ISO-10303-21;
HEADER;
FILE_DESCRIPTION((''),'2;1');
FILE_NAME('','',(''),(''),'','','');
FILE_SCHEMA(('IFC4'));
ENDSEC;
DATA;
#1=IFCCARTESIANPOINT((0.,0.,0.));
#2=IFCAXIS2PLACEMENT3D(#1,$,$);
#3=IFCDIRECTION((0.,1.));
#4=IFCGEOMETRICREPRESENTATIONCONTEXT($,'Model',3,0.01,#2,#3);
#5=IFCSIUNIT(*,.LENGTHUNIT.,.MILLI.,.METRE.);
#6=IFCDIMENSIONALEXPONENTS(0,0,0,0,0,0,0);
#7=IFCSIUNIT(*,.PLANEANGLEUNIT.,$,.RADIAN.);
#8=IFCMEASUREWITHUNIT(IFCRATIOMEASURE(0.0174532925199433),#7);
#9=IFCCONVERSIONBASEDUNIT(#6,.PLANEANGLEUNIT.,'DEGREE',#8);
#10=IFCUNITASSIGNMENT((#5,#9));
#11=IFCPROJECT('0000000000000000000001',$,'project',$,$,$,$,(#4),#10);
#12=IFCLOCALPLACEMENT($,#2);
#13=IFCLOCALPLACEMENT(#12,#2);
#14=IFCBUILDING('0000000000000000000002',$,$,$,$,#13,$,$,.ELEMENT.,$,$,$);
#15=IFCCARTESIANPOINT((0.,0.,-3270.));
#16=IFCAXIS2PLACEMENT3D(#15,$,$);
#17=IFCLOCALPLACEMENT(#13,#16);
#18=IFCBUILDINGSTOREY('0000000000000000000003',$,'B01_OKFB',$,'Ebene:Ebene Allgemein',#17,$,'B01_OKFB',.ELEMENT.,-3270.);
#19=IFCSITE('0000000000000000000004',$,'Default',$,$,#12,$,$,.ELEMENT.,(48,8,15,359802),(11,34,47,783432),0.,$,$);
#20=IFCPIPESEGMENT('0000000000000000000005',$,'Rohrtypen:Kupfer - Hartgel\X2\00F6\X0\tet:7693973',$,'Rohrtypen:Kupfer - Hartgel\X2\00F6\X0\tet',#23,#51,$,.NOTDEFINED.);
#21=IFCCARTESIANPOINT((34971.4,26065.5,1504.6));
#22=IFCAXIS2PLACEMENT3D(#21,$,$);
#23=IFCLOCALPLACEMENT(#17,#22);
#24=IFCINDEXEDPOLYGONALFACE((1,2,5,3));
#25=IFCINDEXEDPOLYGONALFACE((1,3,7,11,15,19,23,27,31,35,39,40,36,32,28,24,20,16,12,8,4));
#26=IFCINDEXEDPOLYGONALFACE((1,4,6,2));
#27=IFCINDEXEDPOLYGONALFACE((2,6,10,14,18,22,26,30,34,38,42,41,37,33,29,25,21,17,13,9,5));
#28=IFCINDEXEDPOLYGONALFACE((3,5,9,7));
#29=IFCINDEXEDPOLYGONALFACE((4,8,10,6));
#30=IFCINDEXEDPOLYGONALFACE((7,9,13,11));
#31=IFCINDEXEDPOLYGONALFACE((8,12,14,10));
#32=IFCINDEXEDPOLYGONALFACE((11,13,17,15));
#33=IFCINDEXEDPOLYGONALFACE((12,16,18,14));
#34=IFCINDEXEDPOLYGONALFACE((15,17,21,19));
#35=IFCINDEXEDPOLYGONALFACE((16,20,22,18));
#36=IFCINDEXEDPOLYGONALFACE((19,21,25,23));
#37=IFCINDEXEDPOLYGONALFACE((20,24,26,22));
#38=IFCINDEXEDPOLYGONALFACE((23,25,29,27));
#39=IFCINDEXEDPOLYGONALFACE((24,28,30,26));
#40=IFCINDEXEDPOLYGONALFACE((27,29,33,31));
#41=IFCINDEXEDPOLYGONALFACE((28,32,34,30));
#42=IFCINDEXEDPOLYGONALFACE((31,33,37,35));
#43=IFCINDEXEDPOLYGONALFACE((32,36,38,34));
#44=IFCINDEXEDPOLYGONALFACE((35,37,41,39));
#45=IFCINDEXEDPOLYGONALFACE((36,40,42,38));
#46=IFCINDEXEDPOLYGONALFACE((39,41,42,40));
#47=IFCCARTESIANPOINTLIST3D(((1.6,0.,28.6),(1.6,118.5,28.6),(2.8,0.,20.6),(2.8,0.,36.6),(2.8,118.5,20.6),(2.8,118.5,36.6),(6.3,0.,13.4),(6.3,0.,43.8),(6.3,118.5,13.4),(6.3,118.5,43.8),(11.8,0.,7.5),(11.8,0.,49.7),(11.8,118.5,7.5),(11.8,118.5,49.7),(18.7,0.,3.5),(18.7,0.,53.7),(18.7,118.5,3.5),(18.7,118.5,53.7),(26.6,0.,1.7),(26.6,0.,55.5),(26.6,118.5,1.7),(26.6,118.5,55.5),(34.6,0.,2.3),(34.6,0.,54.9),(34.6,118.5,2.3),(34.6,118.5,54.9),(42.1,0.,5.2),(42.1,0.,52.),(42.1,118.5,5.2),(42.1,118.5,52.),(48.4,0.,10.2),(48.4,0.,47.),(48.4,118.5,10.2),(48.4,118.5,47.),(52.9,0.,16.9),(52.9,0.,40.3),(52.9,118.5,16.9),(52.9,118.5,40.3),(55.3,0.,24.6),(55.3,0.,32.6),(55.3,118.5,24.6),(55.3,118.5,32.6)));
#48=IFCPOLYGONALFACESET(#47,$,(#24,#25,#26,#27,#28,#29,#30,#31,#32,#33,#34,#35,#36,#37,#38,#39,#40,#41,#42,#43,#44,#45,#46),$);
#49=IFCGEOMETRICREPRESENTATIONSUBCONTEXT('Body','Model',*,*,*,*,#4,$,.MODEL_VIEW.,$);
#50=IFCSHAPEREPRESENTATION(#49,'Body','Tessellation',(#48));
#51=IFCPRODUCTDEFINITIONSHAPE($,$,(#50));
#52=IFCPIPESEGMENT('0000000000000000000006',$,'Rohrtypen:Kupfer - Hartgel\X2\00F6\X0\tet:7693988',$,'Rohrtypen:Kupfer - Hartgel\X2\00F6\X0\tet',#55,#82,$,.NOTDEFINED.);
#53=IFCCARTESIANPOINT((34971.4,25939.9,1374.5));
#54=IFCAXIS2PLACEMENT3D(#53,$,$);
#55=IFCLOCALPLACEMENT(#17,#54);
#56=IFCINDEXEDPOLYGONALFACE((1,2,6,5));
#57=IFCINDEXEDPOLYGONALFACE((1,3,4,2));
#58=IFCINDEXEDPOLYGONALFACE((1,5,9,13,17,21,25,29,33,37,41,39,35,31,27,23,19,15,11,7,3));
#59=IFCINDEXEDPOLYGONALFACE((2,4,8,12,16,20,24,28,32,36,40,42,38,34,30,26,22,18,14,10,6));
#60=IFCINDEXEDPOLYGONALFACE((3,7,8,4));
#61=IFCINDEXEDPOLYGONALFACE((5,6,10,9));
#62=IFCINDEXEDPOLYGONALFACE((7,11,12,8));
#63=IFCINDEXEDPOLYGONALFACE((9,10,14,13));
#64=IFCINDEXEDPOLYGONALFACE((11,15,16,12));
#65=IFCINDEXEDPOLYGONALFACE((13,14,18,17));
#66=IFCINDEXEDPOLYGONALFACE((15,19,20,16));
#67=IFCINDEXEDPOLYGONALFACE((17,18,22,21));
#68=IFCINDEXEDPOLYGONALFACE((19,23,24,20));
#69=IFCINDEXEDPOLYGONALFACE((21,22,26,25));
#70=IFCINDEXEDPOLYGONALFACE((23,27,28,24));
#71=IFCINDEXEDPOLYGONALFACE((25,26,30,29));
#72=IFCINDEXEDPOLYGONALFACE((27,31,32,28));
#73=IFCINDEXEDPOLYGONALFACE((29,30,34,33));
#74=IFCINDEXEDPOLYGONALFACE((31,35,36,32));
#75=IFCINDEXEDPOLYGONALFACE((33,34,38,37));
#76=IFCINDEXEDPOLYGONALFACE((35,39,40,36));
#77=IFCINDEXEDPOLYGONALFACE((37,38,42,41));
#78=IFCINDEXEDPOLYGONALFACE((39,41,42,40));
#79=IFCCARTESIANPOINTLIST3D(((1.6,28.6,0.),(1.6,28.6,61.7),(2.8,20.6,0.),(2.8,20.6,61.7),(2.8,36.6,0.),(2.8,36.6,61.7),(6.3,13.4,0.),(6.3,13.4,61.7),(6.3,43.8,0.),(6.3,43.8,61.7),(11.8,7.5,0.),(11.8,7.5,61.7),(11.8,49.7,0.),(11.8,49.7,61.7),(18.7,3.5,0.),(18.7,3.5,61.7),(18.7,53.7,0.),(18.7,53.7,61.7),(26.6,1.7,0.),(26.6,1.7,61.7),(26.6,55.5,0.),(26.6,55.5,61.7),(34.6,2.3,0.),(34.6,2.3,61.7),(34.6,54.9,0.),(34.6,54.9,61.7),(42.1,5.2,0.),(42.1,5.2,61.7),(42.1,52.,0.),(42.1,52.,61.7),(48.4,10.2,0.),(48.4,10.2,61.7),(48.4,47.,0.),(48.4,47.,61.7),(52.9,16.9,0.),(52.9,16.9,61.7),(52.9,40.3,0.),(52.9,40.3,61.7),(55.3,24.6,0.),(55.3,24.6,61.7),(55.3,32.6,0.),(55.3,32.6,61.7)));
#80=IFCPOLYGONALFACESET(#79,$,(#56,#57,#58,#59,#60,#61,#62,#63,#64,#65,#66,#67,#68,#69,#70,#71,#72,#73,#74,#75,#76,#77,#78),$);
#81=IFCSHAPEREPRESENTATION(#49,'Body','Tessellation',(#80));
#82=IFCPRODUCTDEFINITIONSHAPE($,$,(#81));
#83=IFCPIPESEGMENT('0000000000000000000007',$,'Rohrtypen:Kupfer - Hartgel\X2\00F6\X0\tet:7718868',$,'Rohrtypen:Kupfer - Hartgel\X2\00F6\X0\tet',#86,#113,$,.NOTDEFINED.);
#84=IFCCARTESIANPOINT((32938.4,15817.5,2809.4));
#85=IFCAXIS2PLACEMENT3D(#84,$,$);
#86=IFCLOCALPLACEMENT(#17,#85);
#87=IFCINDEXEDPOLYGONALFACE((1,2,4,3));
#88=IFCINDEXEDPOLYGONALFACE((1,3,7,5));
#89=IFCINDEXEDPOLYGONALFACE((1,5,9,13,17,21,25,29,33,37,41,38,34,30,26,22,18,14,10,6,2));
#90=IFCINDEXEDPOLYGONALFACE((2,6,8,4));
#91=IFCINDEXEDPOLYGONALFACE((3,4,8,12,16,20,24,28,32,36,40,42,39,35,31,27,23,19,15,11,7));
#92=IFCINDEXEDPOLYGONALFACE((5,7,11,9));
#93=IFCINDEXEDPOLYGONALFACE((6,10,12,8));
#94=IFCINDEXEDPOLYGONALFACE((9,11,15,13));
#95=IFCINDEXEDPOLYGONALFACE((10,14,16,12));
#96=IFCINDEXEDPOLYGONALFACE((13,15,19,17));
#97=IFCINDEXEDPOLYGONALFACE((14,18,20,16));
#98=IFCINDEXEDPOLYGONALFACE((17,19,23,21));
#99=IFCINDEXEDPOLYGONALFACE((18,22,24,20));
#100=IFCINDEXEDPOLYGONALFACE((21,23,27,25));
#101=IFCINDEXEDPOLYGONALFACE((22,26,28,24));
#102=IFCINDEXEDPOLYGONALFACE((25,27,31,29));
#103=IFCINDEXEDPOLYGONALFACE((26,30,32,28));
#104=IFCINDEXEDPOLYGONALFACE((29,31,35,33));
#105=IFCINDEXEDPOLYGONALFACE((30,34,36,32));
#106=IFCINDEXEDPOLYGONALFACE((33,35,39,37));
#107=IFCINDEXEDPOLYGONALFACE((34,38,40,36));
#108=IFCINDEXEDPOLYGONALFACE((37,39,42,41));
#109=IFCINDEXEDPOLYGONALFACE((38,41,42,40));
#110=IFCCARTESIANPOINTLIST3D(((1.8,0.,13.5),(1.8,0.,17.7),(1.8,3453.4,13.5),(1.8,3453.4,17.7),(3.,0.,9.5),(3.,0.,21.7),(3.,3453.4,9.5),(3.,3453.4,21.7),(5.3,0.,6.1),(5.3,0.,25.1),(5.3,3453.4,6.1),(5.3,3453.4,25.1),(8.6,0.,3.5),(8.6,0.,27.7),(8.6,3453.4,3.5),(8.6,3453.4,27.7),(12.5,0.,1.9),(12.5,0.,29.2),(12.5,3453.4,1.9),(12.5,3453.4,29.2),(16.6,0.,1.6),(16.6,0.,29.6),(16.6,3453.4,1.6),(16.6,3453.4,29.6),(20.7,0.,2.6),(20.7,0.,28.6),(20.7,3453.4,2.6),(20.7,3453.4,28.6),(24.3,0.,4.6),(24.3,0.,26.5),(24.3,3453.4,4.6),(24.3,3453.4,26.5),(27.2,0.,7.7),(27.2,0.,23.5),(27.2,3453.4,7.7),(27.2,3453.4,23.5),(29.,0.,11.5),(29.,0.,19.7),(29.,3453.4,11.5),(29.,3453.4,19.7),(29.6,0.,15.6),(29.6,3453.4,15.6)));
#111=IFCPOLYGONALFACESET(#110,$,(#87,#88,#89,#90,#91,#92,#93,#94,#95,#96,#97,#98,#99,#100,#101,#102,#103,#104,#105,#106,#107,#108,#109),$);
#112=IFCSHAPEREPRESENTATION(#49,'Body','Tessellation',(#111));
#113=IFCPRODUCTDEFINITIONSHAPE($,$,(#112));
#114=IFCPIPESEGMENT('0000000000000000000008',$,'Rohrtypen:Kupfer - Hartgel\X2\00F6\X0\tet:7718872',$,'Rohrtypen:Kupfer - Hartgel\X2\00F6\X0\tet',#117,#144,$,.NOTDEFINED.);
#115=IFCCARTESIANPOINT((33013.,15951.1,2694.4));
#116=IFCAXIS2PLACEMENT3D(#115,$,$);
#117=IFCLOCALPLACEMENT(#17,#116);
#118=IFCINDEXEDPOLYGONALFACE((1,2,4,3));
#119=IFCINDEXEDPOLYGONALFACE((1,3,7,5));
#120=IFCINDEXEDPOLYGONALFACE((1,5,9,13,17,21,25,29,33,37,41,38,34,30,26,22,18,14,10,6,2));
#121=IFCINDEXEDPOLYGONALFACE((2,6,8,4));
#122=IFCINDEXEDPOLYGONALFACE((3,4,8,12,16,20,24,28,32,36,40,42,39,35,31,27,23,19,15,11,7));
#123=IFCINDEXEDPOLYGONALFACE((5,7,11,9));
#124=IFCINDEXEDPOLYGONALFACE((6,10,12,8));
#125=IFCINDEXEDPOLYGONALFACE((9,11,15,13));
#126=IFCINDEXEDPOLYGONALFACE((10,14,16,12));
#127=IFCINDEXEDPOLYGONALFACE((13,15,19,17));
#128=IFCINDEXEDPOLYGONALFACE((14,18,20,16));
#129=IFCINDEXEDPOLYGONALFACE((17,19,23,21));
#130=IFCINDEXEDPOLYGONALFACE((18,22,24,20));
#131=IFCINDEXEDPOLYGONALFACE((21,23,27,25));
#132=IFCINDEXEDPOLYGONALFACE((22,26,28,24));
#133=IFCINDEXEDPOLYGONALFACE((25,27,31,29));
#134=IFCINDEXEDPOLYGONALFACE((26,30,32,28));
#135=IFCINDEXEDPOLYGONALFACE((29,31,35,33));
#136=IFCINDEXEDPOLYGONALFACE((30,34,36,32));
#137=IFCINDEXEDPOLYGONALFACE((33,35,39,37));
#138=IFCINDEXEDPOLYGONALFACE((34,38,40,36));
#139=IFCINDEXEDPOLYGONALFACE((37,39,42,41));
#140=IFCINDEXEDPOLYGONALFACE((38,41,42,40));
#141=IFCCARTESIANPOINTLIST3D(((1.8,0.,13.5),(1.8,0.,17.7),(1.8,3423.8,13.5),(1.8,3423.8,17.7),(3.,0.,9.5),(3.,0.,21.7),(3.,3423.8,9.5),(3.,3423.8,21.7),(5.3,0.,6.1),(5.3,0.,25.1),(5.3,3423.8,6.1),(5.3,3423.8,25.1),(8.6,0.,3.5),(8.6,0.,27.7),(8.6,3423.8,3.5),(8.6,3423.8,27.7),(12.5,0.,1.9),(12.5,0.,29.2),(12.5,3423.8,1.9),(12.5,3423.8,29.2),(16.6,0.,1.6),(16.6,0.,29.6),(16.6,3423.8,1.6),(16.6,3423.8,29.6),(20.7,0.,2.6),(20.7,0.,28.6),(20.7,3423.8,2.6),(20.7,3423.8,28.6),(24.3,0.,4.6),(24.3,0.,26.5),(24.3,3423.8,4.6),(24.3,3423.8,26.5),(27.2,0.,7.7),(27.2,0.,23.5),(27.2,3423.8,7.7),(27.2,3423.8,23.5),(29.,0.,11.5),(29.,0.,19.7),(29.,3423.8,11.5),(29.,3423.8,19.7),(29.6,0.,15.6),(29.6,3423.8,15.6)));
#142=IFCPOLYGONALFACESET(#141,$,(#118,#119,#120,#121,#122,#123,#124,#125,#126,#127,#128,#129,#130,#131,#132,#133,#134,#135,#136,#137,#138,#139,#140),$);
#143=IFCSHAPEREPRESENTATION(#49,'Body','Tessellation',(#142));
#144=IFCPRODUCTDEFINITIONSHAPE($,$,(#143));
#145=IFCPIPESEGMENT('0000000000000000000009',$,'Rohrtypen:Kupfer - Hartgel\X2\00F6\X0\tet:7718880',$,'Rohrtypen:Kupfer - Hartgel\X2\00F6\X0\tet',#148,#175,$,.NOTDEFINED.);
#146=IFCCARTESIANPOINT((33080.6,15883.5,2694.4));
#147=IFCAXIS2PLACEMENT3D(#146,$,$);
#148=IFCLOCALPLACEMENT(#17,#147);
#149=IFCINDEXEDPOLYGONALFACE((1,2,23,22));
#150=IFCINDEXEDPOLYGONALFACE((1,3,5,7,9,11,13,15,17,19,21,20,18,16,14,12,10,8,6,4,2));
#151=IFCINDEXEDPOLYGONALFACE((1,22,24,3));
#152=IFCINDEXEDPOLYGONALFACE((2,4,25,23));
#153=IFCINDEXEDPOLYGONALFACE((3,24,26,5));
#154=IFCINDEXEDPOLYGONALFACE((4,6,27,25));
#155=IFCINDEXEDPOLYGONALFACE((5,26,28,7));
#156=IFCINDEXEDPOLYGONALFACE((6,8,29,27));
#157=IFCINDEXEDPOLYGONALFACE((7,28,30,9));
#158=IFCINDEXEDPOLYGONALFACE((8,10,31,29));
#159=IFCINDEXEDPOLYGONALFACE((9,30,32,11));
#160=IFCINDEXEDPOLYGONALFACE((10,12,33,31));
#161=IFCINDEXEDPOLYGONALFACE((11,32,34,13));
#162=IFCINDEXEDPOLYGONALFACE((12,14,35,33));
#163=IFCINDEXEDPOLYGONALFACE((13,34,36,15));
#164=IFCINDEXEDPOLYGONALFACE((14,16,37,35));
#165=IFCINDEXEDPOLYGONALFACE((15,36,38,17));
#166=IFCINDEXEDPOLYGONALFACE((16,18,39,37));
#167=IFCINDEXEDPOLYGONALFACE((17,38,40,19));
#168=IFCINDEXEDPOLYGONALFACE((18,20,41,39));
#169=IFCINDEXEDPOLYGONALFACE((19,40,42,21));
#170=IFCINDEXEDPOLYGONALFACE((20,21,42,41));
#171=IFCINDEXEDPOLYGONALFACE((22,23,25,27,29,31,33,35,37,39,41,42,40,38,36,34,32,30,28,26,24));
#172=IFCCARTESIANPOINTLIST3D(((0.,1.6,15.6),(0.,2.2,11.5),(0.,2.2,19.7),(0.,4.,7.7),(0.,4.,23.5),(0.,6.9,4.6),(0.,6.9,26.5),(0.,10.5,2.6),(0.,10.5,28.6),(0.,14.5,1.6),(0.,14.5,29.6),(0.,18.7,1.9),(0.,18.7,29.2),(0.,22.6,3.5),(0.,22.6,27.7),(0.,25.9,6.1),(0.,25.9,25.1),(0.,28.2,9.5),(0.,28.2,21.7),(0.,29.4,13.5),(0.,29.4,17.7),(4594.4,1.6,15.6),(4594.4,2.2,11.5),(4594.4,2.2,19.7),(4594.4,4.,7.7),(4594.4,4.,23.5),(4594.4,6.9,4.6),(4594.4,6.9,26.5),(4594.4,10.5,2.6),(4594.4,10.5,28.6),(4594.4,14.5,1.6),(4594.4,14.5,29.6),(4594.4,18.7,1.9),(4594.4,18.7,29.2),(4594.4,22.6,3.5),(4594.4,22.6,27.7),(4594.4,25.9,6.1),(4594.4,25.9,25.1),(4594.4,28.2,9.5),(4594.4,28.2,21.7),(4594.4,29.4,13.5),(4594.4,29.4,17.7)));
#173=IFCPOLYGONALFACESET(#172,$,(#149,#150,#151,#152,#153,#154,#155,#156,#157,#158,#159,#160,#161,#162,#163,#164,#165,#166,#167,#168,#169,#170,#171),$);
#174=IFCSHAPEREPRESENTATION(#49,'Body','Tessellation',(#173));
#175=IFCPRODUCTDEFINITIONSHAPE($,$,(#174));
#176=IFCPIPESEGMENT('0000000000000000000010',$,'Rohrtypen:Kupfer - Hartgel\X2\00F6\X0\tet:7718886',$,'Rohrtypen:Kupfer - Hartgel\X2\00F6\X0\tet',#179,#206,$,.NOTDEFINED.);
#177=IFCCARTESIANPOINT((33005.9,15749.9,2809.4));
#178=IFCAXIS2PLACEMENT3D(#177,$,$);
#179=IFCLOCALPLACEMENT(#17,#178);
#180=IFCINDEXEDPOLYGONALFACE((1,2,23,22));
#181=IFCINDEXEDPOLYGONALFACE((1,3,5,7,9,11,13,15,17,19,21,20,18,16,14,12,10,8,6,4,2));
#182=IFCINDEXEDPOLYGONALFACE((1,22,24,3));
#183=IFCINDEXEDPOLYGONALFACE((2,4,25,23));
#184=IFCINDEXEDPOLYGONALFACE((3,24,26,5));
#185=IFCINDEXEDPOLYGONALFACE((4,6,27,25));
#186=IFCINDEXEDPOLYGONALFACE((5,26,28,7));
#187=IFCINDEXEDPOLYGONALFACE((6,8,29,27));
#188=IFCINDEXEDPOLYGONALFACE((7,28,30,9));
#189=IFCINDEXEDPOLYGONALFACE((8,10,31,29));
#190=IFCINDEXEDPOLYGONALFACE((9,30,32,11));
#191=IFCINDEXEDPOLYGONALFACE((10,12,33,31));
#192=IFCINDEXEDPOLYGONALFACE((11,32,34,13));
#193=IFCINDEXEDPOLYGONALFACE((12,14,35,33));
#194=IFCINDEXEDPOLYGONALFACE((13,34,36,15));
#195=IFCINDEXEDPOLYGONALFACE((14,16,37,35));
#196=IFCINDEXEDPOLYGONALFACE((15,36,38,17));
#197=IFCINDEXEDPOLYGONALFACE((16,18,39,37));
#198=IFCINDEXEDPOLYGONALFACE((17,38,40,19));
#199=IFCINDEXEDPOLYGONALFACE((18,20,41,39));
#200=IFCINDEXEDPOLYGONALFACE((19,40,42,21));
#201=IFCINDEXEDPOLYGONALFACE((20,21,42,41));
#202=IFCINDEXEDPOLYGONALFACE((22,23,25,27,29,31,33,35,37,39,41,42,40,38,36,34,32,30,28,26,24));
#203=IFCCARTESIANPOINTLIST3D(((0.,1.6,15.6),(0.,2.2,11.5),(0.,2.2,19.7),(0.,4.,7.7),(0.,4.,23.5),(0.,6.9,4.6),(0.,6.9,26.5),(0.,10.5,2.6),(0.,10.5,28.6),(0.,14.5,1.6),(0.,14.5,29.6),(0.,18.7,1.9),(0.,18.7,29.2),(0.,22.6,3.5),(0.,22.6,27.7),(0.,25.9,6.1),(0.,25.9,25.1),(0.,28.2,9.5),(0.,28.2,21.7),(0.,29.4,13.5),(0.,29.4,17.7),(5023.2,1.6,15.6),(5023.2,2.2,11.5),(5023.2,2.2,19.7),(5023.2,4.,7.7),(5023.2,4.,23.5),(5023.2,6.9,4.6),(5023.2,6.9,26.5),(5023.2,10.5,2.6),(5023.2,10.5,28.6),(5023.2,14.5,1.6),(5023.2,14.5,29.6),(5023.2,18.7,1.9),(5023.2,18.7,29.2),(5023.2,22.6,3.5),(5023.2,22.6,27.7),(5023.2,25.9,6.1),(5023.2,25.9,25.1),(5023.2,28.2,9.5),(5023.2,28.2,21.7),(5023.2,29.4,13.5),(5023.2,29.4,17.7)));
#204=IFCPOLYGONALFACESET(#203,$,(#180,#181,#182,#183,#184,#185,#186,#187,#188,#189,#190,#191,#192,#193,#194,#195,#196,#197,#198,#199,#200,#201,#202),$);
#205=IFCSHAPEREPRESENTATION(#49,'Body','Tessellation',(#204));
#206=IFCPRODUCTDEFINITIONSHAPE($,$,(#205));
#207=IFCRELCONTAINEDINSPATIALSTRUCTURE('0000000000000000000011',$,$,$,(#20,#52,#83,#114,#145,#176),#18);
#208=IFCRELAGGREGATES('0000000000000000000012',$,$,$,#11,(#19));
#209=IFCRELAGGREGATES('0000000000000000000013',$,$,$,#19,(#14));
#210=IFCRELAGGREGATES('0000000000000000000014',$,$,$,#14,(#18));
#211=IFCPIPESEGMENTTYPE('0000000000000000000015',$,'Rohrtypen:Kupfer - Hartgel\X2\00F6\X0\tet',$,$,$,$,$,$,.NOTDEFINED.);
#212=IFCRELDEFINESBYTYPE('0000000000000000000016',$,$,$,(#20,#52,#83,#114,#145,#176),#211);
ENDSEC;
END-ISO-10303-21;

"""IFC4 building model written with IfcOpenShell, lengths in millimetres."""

from ifc_helpers import new_model, entity, si_unit, converted_unit, direction, frame, frame_2d, origin, origin_2d_with_axis, place, context, subcontext, project, spatial, circle, extrude, type_object, element, save


model = new_model("IFC4")

# Units and contexts
model_context = context("Model", 3, precision=0.01, world=origin(), true_north=direction((0.0, 1.0)))
body_context = subcontext(model_context, "Body", "Model", "MODEL_VIEW")
ifc_project = project(units=[si_unit("LENGTHUNIT", "METRE", prefix="MILLI"), converted_unit("PLANEANGLEUNIT", "DEGREE", entity("IfcRatioMeasure", 0.0174532925199433), si_unit("PLANEANGLEUNIT", "RADIAN"), dimensions=[0, 0, 0, 0, 0, 0, 0])], contexts=[model_context])

# Site, building, storey
site_placement = place(None, origin())
site = spatial("IfcSite", under=ifc_project, at=site_placement, Name="Default", CompositionType="ELEMENT", RefLatitude=(48, 8, 15, 359802), RefLongitude=(11, 34, 47, 783432), RefElevation=0.0)
building_placement = place(site_placement, origin())
building = spatial("IfcBuilding", under=site, at=building_placement, CompositionType="ELEMENT")
storey_placement = place(building_placement, frame((0.0, 0.0, -3270.0)))
storey = spatial("IfcBuildingStorey", under=building, at=storey_placement, Name="B01_OKFB", ObjectType="Ebene:Ebene Allgemein", LongName="B01_OKFB", CompositionType="ELEMENT", Elevation=-3270.0)

# Pipe segments
pipe_segment_type = type_object("IfcPipeSegmentType", Name="Rohrtypen:Kupfer - Hartgelötet", PredefinedType="NOTDEFINED")
pipe_segment_1_placement = place(storey_placement, frame((34971.4, 26065.5, 1504.6)))
element("IfcPipeSegment", 1, at=pipe_segment_1_placement, inside=storey, type_object=pipe_segment_type, Name="Rohrtypen:Kupfer - Hartgelötet:7693973", ObjectType="Rohrtypen:Kupfer - Hartgelötet", PredefinedType="NOTDEFINED", context=body_context, shape_type="SweptSolid", body=[
    extrude(circle(Radius=27.0, at=frame_2d((0.0, 0.0), x_axis=(1.0, 0.0))), frame((28.6, 0.0, 28.6), z_axis=(0.0, 1.0, 0.0), x_axis=(-1.0, 0.0, 0.0)), (0.0, 0.0, 1.0), 118.5),
])
pipe_segment_2_placement = place(storey_placement, frame((34971.4, 25939.9, 1374.5)))
element("IfcPipeSegment", 2, at=pipe_segment_2_placement, inside=storey, type_object=pipe_segment_type, Name="Rohrtypen:Kupfer - Hartgelötet:7693988", ObjectType="Rohrtypen:Kupfer - Hartgelötet", PredefinedType="NOTDEFINED", context=body_context, shape_type="SweptSolid", body=[
    extrude(circle(Radius=27.0, at=origin_2d_with_axis()), frame((28.6, 28.6, 0.0), z_axis=(0.0, 0.0, 1.0), x_axis=(-1.0, 0.0, 0.0)), (0.0, 0.0, 1.0), 61.7),
])
pipe_segment_3_placement = place(storey_placement, frame((32938.4, 15817.5, 2809.4)))
element("IfcPipeSegment", 3, at=pipe_segment_3_placement, inside=storey, type_object=pipe_segment_type, Name="Rohrtypen:Kupfer - Hartgelötet:7718868", ObjectType="Rohrtypen:Kupfer - Hartgelötet", PredefinedType="NOTDEFINED", context=body_context, shape_type="SweptSolid", body=[
    extrude(circle(Radius=14.0, at=origin_2d_with_axis()), frame((15.6, 0.0, 15.6), z_axis=(0.0, 1.0, 0.0), x_axis=(1.0, 0.0, 0.0)), (0.0, 0.0, 1.0), 3453.4),
])
pipe_segment_4_placement = place(storey_placement, frame((33013.0, 15951.1, 2694.4)))
element("IfcPipeSegment", 4, at=pipe_segment_4_placement, inside=storey, type_object=pipe_segment_type, Name="Rohrtypen:Kupfer - Hartgelötet:7718872", ObjectType="Rohrtypen:Kupfer - Hartgelötet", PredefinedType="NOTDEFINED", context=body_context, shape_type="SweptSolid", body=[
    extrude(circle(Radius=14.0, at=origin_2d_with_axis()), frame((15.6, 0.0, 15.6), z_axis=(0.0, 1.0, 0.0), x_axis=(1.0, 0.0, 0.0)), (0.0, 0.0, 1.0), 3423.8),
])
pipe_segment_5_placement = place(storey_placement, frame((33080.6, 15883.5, 2694.4)))
element("IfcPipeSegment", 5, at=pipe_segment_5_placement, inside=storey, type_object=pipe_segment_type, Name="Rohrtypen:Kupfer - Hartgelötet:7718880", ObjectType="Rohrtypen:Kupfer - Hartgelötet", PredefinedType="NOTDEFINED", context=body_context, shape_type="SweptSolid", body=[
    extrude(circle(Radius=14.0, at=origin_2d_with_axis()), frame((0.0, 15.6, 15.6), z_axis=(1.0, 0.0, 0.0), x_axis=(0.0, -1.0, 0.0)), (0.0, 0.0, 1.0), 4594.4),
])
pipe_segment_6_placement = place(storey_placement, frame((33005.9, 15749.9, 2809.4)))
element("IfcPipeSegment", 6, at=pipe_segment_6_placement, inside=storey, type_object=pipe_segment_type, Name="Rohrtypen:Kupfer - Hartgelötet:7718886", ObjectType="Rohrtypen:Kupfer - Hartgelötet", PredefinedType="NOTDEFINED", context=body_context, shape_type="SweptSolid", body=[
    extrude(circle(Radius=14.0, at=origin_2d_with_axis()), frame((0.0, 15.6, 15.6), z_axis=(1.0, 0.0, 0.0), x_axis=(0.0, -1.0, 0.0)), (0.0, 0.0, 1.0), 5023.2),
])

save(model, "model.ifc")
